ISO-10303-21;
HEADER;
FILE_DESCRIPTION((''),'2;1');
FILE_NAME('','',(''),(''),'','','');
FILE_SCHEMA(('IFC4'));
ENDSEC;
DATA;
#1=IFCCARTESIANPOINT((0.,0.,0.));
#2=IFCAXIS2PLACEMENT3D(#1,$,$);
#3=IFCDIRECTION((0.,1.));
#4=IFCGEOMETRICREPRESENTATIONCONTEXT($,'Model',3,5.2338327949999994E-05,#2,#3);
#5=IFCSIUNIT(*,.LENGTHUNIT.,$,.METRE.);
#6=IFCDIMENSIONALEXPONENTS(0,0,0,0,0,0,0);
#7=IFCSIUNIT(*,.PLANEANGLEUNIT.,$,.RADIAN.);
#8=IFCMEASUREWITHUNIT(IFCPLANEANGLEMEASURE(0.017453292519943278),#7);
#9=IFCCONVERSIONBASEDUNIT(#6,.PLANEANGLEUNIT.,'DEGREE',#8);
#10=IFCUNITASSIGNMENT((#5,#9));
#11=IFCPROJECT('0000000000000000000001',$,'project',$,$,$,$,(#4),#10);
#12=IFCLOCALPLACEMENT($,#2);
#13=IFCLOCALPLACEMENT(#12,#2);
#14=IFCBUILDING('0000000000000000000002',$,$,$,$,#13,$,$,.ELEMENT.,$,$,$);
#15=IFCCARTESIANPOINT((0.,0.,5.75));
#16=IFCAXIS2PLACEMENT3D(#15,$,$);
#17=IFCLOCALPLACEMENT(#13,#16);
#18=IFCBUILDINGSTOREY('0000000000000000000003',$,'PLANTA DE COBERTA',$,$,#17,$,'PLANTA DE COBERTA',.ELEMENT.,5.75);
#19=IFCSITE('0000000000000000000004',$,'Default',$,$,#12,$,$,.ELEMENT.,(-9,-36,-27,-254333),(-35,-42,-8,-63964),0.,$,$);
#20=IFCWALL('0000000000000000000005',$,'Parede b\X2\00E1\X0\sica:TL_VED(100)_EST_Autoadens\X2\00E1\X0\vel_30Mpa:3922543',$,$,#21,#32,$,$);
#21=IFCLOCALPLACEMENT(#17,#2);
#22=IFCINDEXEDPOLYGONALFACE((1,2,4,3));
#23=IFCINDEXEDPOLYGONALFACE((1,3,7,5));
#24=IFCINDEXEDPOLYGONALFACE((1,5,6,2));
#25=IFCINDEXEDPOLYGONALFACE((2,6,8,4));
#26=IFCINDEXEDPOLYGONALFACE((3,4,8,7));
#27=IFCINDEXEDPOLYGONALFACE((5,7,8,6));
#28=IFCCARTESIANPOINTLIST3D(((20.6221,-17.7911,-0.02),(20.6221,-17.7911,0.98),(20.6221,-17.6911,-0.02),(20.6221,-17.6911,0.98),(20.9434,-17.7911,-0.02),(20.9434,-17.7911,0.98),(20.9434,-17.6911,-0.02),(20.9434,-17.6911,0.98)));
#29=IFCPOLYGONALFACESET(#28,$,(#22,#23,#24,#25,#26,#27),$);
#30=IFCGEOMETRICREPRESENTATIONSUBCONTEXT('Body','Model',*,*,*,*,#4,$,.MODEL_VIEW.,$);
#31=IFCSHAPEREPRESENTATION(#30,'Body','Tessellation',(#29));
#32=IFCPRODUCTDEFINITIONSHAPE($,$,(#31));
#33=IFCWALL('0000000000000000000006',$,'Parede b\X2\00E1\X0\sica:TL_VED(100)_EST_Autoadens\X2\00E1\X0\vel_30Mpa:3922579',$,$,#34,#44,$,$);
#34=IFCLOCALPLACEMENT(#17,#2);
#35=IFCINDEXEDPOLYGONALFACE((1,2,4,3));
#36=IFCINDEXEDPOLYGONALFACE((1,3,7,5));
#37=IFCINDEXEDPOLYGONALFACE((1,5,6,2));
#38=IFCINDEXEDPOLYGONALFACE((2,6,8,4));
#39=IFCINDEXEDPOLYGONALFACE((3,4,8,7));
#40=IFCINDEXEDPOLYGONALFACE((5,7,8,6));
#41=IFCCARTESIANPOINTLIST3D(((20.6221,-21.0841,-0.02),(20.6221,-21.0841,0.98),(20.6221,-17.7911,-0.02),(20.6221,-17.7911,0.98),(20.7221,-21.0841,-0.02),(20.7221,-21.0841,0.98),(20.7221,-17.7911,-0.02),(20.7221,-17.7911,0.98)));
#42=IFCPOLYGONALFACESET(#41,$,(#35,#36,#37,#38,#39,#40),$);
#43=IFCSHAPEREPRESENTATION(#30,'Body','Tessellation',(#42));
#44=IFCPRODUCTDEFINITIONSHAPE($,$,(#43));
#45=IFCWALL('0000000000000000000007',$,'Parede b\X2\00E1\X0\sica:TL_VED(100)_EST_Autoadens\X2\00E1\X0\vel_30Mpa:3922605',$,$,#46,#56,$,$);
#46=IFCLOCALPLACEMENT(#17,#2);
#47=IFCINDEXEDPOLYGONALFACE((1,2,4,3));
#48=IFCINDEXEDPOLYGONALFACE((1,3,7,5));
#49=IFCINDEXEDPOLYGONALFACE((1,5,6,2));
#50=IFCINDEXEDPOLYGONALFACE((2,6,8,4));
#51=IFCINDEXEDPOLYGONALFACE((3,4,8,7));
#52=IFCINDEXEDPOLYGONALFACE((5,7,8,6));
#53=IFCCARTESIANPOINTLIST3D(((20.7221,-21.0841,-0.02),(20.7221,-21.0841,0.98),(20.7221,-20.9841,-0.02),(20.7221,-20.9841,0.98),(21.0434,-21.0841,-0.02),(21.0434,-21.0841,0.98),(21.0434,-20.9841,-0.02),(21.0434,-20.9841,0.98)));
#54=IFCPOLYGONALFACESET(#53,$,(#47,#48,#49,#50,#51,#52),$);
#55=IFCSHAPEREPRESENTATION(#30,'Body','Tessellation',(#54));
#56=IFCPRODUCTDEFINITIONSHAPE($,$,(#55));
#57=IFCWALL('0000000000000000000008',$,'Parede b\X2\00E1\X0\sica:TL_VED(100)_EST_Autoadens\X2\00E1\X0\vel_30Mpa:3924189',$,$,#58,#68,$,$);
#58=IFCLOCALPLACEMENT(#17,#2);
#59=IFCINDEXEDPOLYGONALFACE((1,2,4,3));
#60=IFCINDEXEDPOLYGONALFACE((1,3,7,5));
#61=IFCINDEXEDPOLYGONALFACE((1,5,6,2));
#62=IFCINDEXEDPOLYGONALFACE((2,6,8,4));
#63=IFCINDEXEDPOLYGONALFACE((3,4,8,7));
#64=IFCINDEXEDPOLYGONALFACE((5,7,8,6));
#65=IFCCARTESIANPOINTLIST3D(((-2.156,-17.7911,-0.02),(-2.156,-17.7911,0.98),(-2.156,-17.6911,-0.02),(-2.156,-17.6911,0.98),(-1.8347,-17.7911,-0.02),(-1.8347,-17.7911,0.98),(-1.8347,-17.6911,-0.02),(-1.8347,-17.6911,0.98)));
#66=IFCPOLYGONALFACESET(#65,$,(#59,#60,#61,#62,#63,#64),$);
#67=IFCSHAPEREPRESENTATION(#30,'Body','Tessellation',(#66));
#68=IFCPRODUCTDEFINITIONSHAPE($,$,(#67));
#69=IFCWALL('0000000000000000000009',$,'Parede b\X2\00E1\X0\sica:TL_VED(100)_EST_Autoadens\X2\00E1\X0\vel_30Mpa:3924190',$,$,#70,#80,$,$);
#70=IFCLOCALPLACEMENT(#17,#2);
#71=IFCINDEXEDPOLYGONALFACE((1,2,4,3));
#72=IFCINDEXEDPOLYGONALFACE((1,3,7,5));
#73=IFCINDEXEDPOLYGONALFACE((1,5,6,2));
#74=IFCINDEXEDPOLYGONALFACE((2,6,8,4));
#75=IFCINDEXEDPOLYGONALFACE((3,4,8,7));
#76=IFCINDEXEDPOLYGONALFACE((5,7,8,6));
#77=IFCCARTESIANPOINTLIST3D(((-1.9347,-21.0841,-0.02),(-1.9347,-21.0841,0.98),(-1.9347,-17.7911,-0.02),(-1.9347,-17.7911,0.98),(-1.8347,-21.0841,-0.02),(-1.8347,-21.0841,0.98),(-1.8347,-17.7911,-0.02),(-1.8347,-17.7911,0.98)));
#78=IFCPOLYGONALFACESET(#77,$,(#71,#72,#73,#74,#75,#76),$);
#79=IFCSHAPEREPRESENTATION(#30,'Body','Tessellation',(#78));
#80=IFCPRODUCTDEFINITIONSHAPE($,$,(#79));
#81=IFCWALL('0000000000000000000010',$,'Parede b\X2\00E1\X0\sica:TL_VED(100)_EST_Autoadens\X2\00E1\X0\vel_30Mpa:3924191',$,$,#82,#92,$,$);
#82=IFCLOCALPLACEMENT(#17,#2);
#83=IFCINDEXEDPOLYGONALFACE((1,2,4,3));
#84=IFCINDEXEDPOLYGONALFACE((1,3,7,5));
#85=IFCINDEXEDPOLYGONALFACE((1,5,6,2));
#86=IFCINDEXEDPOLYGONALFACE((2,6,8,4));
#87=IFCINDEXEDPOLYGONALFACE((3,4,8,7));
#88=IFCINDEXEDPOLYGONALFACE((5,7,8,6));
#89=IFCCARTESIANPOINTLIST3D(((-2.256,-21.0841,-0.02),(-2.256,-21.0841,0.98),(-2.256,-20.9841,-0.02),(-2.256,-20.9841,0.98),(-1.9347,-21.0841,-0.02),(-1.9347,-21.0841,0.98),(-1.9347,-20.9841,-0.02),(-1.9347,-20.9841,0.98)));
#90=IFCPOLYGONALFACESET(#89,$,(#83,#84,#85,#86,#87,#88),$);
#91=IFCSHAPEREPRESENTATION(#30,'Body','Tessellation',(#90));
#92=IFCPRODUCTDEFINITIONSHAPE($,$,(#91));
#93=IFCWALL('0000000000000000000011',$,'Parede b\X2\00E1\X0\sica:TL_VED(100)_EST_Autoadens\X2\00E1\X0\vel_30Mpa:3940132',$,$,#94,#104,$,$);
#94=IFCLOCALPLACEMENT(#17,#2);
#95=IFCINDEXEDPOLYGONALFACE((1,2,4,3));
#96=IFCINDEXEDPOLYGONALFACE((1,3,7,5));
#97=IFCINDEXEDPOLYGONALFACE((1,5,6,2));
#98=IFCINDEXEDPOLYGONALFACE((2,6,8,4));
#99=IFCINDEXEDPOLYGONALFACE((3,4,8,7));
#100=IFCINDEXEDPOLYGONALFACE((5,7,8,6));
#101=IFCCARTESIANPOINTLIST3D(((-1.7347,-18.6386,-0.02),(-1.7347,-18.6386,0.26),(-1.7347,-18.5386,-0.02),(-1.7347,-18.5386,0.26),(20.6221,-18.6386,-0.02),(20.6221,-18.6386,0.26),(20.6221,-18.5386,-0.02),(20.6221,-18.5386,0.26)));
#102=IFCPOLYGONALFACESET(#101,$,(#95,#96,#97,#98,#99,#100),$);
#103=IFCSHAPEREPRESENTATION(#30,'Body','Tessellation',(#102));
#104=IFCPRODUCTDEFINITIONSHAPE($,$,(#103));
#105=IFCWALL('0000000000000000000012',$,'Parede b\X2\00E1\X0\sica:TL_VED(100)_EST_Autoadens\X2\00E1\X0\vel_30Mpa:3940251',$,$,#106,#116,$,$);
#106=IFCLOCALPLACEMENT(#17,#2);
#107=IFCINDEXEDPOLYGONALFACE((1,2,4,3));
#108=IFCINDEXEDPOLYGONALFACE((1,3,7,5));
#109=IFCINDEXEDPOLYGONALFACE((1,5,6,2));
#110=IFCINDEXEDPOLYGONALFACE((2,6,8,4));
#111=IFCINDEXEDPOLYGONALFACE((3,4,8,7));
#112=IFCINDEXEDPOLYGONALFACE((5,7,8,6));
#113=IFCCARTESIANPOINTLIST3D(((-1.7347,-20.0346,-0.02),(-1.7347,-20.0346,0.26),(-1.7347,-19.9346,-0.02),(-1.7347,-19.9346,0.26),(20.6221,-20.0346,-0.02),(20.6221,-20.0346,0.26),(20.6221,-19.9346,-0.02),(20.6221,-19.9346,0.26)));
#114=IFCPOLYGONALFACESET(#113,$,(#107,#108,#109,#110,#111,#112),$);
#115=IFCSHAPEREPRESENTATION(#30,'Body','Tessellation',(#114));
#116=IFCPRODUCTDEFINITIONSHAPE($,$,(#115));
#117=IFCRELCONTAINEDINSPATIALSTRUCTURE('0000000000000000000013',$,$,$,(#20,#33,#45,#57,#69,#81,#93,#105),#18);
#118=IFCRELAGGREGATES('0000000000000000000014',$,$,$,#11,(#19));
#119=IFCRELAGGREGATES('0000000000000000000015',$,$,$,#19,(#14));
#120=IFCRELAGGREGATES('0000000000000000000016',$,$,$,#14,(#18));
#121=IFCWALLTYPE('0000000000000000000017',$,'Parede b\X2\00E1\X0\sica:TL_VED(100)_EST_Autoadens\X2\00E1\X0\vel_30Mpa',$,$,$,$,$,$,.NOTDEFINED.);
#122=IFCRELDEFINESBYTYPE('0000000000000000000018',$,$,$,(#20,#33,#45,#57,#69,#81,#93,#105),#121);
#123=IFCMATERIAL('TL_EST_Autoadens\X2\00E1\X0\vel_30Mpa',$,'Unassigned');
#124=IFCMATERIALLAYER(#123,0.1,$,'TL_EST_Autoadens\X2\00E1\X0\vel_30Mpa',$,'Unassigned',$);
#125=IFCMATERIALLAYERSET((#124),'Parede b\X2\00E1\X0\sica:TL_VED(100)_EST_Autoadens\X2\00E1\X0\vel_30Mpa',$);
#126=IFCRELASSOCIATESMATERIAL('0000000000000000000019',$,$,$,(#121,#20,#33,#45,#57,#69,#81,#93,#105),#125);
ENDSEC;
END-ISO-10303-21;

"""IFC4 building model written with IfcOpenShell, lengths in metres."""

from ifc_helpers import new_model, entity, si_unit, converted_unit, direction, frame, frame_2d, origin, place, context, subcontext, project, spatial, rectangle, extrude, material, layer, layer_set, layer_usage, type_object, element, save


model = new_model("IFC4")

# Units and contexts
model_context = context("Model", 3, precision=5.2338327949999994e-05, world=origin(), true_north=direction((0.0, 1.0)))
body_context = subcontext(model_context, "Body", "Model", "MODEL_VIEW")
ifc_project = project(units=[si_unit("LENGTHUNIT", "METRE"), converted_unit("PLANEANGLEUNIT", "DEGREE", entity("IfcPlaneAngleMeasure", 0.017453292519943278), si_unit("PLANEANGLEUNIT", "RADIAN"), dimensions=[0, 0, 0, 0, 0, 0, 0])], contexts=[model_context])

# Site, building, storey
site_placement = place(None, frame((0.0, 0.0, 0.0)))
site = spatial("IfcSite", under=ifc_project, at=site_placement, Name="Default", CompositionType="ELEMENT", RefLatitude=(-9, -36, -27, -254333), RefLongitude=(-35, -42, -8, -63964), RefElevation=0.0)
building_placement = place(site_placement, origin())
building = spatial("IfcBuilding", under=site, at=building_placement, CompositionType="ELEMENT")
storey_placement = place(building_placement, frame((0.0, 0.0, 5.75)))
storey = spatial("IfcBuildingStorey", under=building, at=storey_placement, Name="PLANTA DE COBERTA", LongName="PLANTA DE COBERTA", CompositionType="ELEMENT", Elevation=5.75)

# Walls
ifc_material_1 = material(Name="TL_EST_Autoadensável_30Mpa", Category="Unassigned")
ifc_layer_1 = layer(ifc_material_1, 0.1, Name="TL_EST_Autoadensável_30Mpa", Category="Unassigned")
ifc_layer_set_1 = layer_set([ifc_layer_1], Name="Parede básica:TL_VED(100)_EST_Autoadensável_30Mpa")
ifc_layer_usage_1 = layer_usage(ifc_layer_set_1, "AXIS2", "POSITIVE", -0.05)
wall_type = type_object("IfcWallType", Name="Parede básica:TL_VED(100)_EST_Autoadensável_30Mpa", PredefinedType="NOTDEFINED", material=ifc_layer_set_1)
wall_1_placement = place(storey_placement, frame((20.9434, -17.7411, -0.02), z_axis=(0.0, 0.0, 1.0), x_axis=(-1.0, 0.0, 0.0)))
element("IfcWall", 1, at=wall_1_placement, inside=storey, type_object=wall_type, material=ifc_layer_usage_1, Name="Parede básica:TL_VED(100)_EST_Autoadensável_30Mpa:3922543", context=body_context, shape_type="SweptSolid", body=[
    extrude(rectangle(XDim=0.3213, YDim=0.1, at=frame_2d((0.1606, 0.0), x_axis=(-1.0, 0.0))), origin(), (0.0, 0.0, 1.0), 1.0),
])
ifc_layer_usage_2 = layer_usage(ifc_layer_set_1, "AXIS2", "POSITIVE", -0.05)
wall_2_placement = place(storey_placement, frame((20.6721, -17.7911, -0.02), z_axis=(0.0, 0.0, 1.0), x_axis=(0.0, -1.0, 0.0)))
element("IfcWall", 2, at=wall_2_placement, inside=storey, type_object=wall_type, material=ifc_layer_usage_2, Name="Parede básica:TL_VED(100)_EST_Autoadensável_30Mpa:3922579", context=body_context, shape_type="SweptSolid", body=[
    extrude(rectangle(XDim=3.293, YDim=0.1, at=frame_2d((1.6465, 0.0), x_axis=(-1.0, 0.0))), origin(), (0.0, 0.0, 1.0), 1.0),
])
ifc_layer_usage_3 = layer_usage(ifc_layer_set_1, "AXIS2", "POSITIVE", -0.05)
wall_3_placement = place(storey_placement, frame((20.7221, -21.0341, -0.02)))
element("IfcWall", 3, at=wall_3_placement, inside=storey, type_object=wall_type, material=ifc_layer_usage_3, Name="Parede básica:TL_VED(100)_EST_Autoadensável_30Mpa:3922605", context=body_context, shape_type="SweptSolid", body=[
    extrude(rectangle(XDim=0.3213, YDim=0.1, at=frame_2d((0.1606, 0.0), x_axis=(-1.0, 0.0))), origin(), (0.0, 0.0, 1.0), 1.0),
])
ifc_layer_usage_4 = layer_usage(ifc_layer_set_1, "AXIS2", "NEGATIVE", 0.05)
wall_4_placement = place(storey_placement, frame((-2.156, -17.7411, -0.02)))
element("IfcWall", 4, at=wall_4_placement, inside=storey, type_object=wall_type, material=ifc_layer_usage_4, Name="Parede básica:TL_VED(100)_EST_Autoadensável_30Mpa:3924189", context=body_context, shape_type="SweptSolid", body=[
    extrude(rectangle(XDim=0.3213, YDim=0.1, at=frame_2d((0.1606, 0.0), x_axis=(-1.0, 0.0))), origin(), (0.0, 0.0, 1.0), 1.0),
])
ifc_layer_usage_5 = layer_usage(ifc_layer_set_1, "AXIS2", "NEGATIVE", 0.05)
wall_5_placement = place(storey_placement, frame((-1.8847, -17.7911, -0.02), z_axis=(0.0, 0.0, 1.0), x_axis=(0.0, -1.0, 0.0)))
element("IfcWall", 5, at=wall_5_placement, inside=storey, type_object=wall_type, material=ifc_layer_usage_5, Name="Parede básica:TL_VED(100)_EST_Autoadensável_30Mpa:3924190", context=body_context, shape_type="SweptSolid", body=[
    extrude(rectangle(XDim=3.293, YDim=0.1, at=frame_2d((1.6465, 0.0), x_axis=(-1.0, 0.0))), origin(), (0.0, 0.0, 1.0), 1.0),
])
ifc_layer_usage_6 = layer_usage(ifc_layer_set_1, "AXIS2", "NEGATIVE", 0.05)
wall_6_placement = place(storey_placement, frame((-1.9347, -21.0341, -0.02), z_axis=(0.0, 0.0, 1.0), x_axis=(-1.0, 0.0, 0.0)))
element("IfcWall", 6, at=wall_6_placement, inside=storey, type_object=wall_type, material=ifc_layer_usage_6, Name="Parede básica:TL_VED(100)_EST_Autoadensável_30Mpa:3924191", context=body_context, shape_type="SweptSolid", body=[
    extrude(rectangle(XDim=0.3213, YDim=0.1, at=frame_2d((0.1606, 0.0), x_axis=(-1.0, 0.0))), origin(), (0.0, 0.0, 1.0), 1.0),
])
ifc_layer_usage_7 = layer_usage(ifc_layer_set_1, "AXIS2", "NEGATIVE", 0.05)
wall_7_placement = place(storey_placement, frame((20.6221, -18.5886, -0.02), z_axis=(0.0, 0.0, 1.0), x_axis=(-1.0, 0.0, 0.0)))
element("IfcWall", 7, at=wall_7_placement, inside=storey, type_object=wall_type, material=ifc_layer_usage_7, Name="Parede básica:TL_VED(100)_EST_Autoadensável_30Mpa:3940132", context=body_context, shape_type="SweptSolid", body=[
    extrude(rectangle(XDim=22.3569, YDim=0.1, at=frame_2d((11.1784, 0.0), x_axis=(-1.0, 0.0))), origin(), (0.0, 0.0, 1.0), 0.28),
])
ifc_layer_usage_8 = layer_usage(ifc_layer_set_1, "AXIS2", "POSITIVE", -0.05)
wall_8_placement = place(storey_placement, frame((20.6221, -19.9846, -0.02), z_axis=(0.0, 0.0, 1.0), x_axis=(-1.0, 0.0, 0.0)))
element("IfcWall", 8, at=wall_8_placement, inside=storey, type_object=wall_type, material=ifc_layer_usage_8, Name="Parede básica:TL_VED(100)_EST_Autoadensável_30Mpa:3940251", context=body_context, shape_type="SweptSolid", body=[
    extrude(rectangle(XDim=22.3569, YDim=0.1, at=frame_2d((11.1784, 0.0), x_axis=(-1.0, 0.0))), origin(), (0.0, 0.0, 1.0), 0.28),
])

save(model, "model.ifc")
